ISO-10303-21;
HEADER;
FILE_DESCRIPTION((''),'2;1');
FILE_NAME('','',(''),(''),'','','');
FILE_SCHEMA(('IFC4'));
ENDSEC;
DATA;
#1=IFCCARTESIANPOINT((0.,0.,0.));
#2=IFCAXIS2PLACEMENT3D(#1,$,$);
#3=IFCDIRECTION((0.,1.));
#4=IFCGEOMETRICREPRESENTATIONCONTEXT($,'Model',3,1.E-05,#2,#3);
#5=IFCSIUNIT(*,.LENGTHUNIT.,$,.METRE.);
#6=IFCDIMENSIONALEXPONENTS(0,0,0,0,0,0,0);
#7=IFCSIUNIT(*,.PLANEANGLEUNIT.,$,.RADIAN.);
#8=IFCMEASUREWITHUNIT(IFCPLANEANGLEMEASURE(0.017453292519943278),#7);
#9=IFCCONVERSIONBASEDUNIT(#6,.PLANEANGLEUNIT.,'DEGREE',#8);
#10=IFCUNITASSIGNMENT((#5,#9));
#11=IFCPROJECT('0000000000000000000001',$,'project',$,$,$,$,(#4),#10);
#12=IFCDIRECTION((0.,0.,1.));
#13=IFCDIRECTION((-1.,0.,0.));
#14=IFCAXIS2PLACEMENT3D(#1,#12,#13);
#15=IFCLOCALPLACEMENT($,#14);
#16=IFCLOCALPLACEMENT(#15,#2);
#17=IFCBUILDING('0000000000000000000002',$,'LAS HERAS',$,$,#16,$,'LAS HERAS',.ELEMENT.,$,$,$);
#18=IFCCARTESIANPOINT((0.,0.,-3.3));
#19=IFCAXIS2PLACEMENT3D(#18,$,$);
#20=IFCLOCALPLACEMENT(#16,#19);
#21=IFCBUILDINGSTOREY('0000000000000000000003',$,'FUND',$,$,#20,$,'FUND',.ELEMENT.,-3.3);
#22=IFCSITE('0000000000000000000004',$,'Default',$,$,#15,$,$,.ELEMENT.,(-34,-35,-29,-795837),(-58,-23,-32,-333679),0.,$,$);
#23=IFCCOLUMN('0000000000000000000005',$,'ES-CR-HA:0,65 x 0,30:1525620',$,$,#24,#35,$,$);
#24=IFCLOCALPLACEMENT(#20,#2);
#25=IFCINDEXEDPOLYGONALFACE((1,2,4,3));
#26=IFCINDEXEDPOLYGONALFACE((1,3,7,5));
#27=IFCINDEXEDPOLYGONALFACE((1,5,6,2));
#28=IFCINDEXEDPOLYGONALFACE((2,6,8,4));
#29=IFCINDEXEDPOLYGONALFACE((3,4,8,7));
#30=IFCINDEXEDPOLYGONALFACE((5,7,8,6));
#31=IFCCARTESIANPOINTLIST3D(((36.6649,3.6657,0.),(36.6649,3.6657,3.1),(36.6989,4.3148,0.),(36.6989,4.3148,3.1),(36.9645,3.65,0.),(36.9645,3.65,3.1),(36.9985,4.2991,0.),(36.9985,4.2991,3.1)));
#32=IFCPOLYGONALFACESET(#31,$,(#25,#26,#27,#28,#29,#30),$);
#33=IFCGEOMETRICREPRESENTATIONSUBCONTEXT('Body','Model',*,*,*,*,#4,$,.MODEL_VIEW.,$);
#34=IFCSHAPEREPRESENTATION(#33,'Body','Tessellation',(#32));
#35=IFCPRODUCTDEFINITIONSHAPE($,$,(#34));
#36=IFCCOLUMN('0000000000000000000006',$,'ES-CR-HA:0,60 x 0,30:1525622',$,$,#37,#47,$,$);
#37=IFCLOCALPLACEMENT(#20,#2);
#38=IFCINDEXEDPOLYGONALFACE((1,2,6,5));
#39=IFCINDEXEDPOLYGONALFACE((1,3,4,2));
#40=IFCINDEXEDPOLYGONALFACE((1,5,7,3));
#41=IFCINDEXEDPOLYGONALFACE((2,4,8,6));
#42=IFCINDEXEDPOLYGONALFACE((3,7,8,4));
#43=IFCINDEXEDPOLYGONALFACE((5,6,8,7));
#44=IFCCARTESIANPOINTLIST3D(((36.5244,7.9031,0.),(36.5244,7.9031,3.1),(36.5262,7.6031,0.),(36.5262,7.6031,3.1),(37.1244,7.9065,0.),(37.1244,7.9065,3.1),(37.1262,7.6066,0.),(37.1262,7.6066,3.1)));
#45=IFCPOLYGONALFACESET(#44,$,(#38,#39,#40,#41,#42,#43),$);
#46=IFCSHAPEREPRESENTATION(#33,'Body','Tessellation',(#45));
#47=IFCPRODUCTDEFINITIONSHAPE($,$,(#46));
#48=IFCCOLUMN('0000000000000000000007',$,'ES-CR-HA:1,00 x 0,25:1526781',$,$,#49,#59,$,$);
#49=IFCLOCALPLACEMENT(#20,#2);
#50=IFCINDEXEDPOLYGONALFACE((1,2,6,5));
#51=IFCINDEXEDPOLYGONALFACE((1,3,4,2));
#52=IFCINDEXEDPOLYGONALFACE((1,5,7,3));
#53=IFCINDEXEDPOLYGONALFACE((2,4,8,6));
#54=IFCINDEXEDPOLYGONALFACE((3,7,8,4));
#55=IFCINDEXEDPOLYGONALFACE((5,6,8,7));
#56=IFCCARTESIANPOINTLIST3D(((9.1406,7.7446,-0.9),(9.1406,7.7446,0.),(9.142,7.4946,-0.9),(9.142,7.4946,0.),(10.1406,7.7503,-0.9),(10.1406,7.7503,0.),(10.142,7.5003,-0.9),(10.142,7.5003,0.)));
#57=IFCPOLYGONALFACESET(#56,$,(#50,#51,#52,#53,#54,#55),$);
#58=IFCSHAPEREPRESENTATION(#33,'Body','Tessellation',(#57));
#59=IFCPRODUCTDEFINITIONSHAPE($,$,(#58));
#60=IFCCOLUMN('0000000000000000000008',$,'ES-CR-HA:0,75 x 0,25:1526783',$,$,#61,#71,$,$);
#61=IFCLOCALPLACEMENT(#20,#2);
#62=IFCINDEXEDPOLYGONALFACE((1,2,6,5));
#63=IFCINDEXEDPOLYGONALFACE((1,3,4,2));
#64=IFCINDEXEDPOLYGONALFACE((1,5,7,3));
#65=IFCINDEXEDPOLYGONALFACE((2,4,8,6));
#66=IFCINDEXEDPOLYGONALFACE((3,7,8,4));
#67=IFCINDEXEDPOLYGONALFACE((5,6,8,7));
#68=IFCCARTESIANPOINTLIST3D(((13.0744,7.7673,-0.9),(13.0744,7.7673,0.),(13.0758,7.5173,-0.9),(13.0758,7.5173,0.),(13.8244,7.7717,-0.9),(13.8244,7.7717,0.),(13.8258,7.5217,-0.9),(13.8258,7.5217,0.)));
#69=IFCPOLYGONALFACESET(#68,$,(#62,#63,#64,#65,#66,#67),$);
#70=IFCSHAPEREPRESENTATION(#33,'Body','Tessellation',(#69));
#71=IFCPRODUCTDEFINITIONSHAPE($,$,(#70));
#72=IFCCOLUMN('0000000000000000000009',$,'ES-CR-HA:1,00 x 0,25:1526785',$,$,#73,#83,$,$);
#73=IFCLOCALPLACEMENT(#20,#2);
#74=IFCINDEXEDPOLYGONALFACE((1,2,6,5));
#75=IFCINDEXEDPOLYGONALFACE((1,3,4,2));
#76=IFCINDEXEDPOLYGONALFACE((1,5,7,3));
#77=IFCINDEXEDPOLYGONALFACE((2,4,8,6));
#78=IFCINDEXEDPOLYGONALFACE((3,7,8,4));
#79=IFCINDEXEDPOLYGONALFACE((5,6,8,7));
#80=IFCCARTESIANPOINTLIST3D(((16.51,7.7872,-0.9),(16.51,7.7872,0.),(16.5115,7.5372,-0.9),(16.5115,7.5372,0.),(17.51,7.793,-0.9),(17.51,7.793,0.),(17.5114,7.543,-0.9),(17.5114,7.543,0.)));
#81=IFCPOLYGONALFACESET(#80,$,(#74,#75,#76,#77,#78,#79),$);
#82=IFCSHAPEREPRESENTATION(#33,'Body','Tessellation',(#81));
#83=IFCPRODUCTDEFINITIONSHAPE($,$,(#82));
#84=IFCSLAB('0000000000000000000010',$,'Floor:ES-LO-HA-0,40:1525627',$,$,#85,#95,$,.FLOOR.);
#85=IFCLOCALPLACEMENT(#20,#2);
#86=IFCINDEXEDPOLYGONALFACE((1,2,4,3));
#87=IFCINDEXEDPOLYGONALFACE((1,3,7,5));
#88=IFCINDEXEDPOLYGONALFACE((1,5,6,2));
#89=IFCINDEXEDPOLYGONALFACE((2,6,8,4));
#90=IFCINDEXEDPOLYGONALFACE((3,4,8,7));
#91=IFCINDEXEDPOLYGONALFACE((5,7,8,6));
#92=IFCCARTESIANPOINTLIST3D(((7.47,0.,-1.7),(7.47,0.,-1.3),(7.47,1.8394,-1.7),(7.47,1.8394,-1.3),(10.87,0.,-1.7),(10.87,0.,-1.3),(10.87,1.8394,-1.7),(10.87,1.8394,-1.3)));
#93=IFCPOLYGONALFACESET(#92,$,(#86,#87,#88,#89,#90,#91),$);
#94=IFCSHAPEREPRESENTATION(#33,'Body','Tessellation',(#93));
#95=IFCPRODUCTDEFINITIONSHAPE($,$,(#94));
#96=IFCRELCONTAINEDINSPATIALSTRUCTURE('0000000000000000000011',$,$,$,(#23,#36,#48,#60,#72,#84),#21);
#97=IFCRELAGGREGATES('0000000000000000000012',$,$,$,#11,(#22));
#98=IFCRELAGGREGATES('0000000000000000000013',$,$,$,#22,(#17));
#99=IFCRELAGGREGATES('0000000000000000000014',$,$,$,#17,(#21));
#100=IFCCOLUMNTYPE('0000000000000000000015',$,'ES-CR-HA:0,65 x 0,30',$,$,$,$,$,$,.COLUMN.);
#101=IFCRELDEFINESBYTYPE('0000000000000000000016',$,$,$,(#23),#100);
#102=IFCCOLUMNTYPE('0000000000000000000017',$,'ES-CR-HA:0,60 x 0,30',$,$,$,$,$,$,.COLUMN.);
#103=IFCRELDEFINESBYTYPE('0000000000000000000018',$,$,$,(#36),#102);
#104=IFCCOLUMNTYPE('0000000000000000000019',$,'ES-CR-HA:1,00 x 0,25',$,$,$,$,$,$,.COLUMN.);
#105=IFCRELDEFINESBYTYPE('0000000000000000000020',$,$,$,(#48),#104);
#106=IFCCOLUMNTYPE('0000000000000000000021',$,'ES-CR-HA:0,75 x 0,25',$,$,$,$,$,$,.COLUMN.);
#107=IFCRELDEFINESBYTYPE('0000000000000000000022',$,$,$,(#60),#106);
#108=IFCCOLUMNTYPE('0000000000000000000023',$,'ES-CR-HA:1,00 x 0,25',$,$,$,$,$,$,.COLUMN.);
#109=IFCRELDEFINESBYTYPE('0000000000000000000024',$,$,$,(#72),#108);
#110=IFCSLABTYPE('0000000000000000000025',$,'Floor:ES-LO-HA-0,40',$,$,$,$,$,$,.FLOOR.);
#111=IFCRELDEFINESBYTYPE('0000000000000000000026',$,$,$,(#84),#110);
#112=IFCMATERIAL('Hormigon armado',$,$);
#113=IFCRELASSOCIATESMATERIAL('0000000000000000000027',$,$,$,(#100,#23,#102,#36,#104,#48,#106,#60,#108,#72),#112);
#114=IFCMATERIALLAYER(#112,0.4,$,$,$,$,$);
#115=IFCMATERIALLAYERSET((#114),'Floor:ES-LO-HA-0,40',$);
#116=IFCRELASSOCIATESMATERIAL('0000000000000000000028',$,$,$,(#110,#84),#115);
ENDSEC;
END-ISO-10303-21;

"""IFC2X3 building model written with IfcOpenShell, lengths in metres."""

from ifc_helpers import new_model, entity, si_unit, converted_unit, direction, frame, frame_2d, origin, origin_2d_with_axis, place, context, subcontext, project, spatial, rectangle, extrude, source, transform, mapped, material, layer, layer_set, layer_usage, type_object, type_shapes, element, save


model = new_model("IFC2X3")

# Units and contexts
model_context = context("Model", 3, precision=1e-05, world=origin(), true_north=direction((0.0, 1.0)))
body_context = subcontext(model_context, "Body", "Model", "MODEL_VIEW")
ifc_project = project(units=[si_unit("LENGTHUNIT", "METRE"), converted_unit("PLANEANGLEUNIT", "DEGREE", entity("IfcPlaneAngleMeasure", 0.017453292519943278), si_unit("PLANEANGLEUNIT", "RADIAN"), dimensions=[0, 0, 0, 0, 0, 0, 0])], contexts=[model_context])

# Site, building, storey
site_placement = place(None, frame((0.0, 0.0, 0.0), z_axis=(0.0, 0.0, 1.0), x_axis=(-1.0, 0.0, 0.0)))
site = spatial("IfcSite", under=ifc_project, at=site_placement, Name="Default", CompositionType="ELEMENT", RefLatitude=(-34, -35, -29, -795837), RefLongitude=(-58, -23, -32, -333679), RefElevation=0.0)
building_placement = place(site_placement, origin())
building = spatial("IfcBuilding", under=site, at=building_placement, Name="LAS HERAS", LongName="LAS HERAS", CompositionType="ELEMENT")
storey_placement = place(building_placement, frame((0.0, 0.0, -3.3)))
storey = spatial("IfcBuildingStorey", under=building, at=storey_placement, Name="FUND", LongName="FUND", CompositionType="ELEMENT", Elevation=-3.3)

# Columns
ifc_material = material(Name="Hormigon armado")
column_type_1 = type_object("IfcColumnType", Name="ES-CR-HA:0,65 x 0,30", PredefinedType="COLUMN", material=ifc_material)
shared_shape_1 = source(origin(), body_context, "Body", "SweptSolid", [
    extrude(rectangle(XDim=0.65, YDim=0.3, at=frame_2d((0.0, 0.0), x_axis=(1.0, 0.0))), frame((36.8317, 3.9824, -3.3), z_axis=(0.0, 0.0, 1.0), x_axis=(-0.052336, -0.99863, 0.0)), (0.0, 0.0, 1.0), 3.1),
])
type_shapes(column_type_1, [shared_shape_1])
column_1_placement = place(storey_placement, frame((0.0, 0.0, 3.3)))
element("IfcColumn", 1, at=column_1_placement, inside=storey, type_object=column_type_1, material=ifc_material, Name="ES-CR-HA:0,65 x 0,30:1525620", context=body_context, shape_type="MappedRepresentation", body=[
    mapped(shared_shape_1, transform((0.0, 0.0, 0.0), scale=1.0)),
])
column_type_2 = type_object("IfcColumnType", Name="ES-CR-HA:0,60 x 0,30", PredefinedType="COLUMN", material=ifc_material)
shared_shape_2 = source(origin(), body_context, "Body", "SweptSolid", [
    extrude(rectangle(XDim=0.6, YDim=0.3, at=frame_2d((0.0, 0.0), x_axis=(1.0, 0.0))), frame((36.8253, 7.7548, -3.3), z_axis=(0.0, 0.0, 1.0), x_axis=(-0.999983, -0.005788, 0.0)), (0.0, 0.0, 1.0), 3.1),
])
type_shapes(column_type_2, [shared_shape_2])
column_2_placement = place(storey_placement, frame((0.0, 0.0, 3.3)))
element("IfcColumn", 2, at=column_2_placement, inside=storey, type_object=column_type_2, material=ifc_material, Name="ES-CR-HA:0,60 x 0,30:1525622", context=body_context, shape_type="MappedRepresentation", body=[
    mapped(shared_shape_2, transform((0.0, 0.0, 0.0), scale=1.0)),
])
column_type_3 = type_object("IfcColumnType", Name="ES-CR-HA:1,00 x 0,25", PredefinedType="COLUMN", material=ifc_material)
shared_shape_3 = source(origin(), body_context, "Body", "SweptSolid", [
    extrude(rectangle(XDim=1.0, YDim=0.25, at=frame_2d((0.0, 0.0), x_axis=(1.0, 0.0))), frame((9.6413, 7.6224, -4.2), z_axis=(0.0, 0.0, 1.0), x_axis=(-0.999983, -0.00576, 0.0)), (0.0, 0.0, 1.0), 0.9),
])
type_shapes(column_type_3, [shared_shape_3])
column_3_placement = place(storey_placement, frame((0.0, 0.0, 3.3)))
element("IfcColumn", 3, at=column_3_placement, inside=storey, type_object=column_type_3, material=ifc_material, Name="ES-CR-HA:1,00 x 0,25:1526781", context=body_context, shape_type="MappedRepresentation", body=[
    mapped(shared_shape_3, transform((0.0, 0.0, 0.0), scale=1.0)),
])
column_type_4 = type_object("IfcColumnType", Name="ES-CR-HA:0,75 x 0,25", PredefinedType="COLUMN", material=ifc_material)
shared_shape_4 = source(origin(), body_context, "Body", "SweptSolid", [
    extrude(rectangle(XDim=0.75, YDim=0.25, at=frame_2d((0.0, 0.0), x_axis=(1.0, 0.0))), frame((13.4501, 7.6445, -4.2), z_axis=(0.0, 0.0, 1.0), x_axis=(-0.999983, -0.00576, 0.0)), (0.0, 0.0, 1.0), 0.9),
])
type_shapes(column_type_4, [shared_shape_4])
column_4_placement = place(storey_placement, frame((0.0, 0.0, 3.3)))
element("IfcColumn", 4, at=column_4_placement, inside=storey, type_object=column_type_4, material=ifc_material, Name="ES-CR-HA:0,75 x 0,25:1526783", context=body_context, shape_type="MappedRepresentation", body=[
    mapped(shared_shape_4, transform((0.0, 0.0, 0.0), scale=1.0)),
])
column_type_5 = type_object("IfcColumnType", Name="ES-CR-HA:1,00 x 0,25", PredefinedType="COLUMN", material=ifc_material)
shared_shape_5 = source(origin(), body_context, "Body", "SweptSolid", [
    extrude(rectangle(XDim=1.0, YDim=0.25, at=frame_2d((0.0, 0.0), x_axis=(1.0, 0.0))), frame((17.0107, 7.6651, -4.2), z_axis=(0.0, 0.0, 1.0), x_axis=(-0.999983, -0.00576, 0.0)), (0.0, 0.0, 1.0), 0.9),
])
type_shapes(column_type_5, [shared_shape_5])
column_5_placement = place(storey_placement, frame((0.0, 0.0, 3.3)))
element("IfcColumn", 5, at=column_5_placement, inside=storey, type_object=column_type_5, material=ifc_material, Name="ES-CR-HA:1,00 x 0,25:1526785", context=body_context, shape_type="MappedRepresentation", body=[
    mapped(shared_shape_5, transform((0.0, 0.0, 0.0), scale=1.0)),
])

# Slab
ifc_layer_1 = layer(ifc_material, 0.4)
ifc_layer_set_1 = layer_set([ifc_layer_1], Name="Floor:ES-LO-HA-0,40")
slab_type_1 = type_object("IfcSlabType", Name="Floor:ES-LO-HA-0,40", PredefinedType="FLOOR", material=ifc_layer_set_1)
ifc_layer_usage_1 = layer_usage(ifc_layer_set_1, "AXIS3", "POSITIVE", 0.0)
slab_1_placement = place(storey_placement, origin())
element("IfcSlab", 6, at=slab_1_placement, inside=storey, type_object=slab_type_1, material=ifc_layer_usage_1, Name="Floor:ES-LO-HA-0,40:1525627", PredefinedType="FLOOR", context=body_context, shape_type="SweptSolid", body=[
    extrude(rectangle(XDim=1.8394, YDim=3.4, at=origin_2d_with_axis()), frame((9.17, 0.9197, -1.3), z_axis=(0.0, 0.0, -1.0), x_axis=(0.0, 1.0, 0.0)), (0.0, 0.0, 1.0), 0.4),
])

save(model, "model.ifc")
